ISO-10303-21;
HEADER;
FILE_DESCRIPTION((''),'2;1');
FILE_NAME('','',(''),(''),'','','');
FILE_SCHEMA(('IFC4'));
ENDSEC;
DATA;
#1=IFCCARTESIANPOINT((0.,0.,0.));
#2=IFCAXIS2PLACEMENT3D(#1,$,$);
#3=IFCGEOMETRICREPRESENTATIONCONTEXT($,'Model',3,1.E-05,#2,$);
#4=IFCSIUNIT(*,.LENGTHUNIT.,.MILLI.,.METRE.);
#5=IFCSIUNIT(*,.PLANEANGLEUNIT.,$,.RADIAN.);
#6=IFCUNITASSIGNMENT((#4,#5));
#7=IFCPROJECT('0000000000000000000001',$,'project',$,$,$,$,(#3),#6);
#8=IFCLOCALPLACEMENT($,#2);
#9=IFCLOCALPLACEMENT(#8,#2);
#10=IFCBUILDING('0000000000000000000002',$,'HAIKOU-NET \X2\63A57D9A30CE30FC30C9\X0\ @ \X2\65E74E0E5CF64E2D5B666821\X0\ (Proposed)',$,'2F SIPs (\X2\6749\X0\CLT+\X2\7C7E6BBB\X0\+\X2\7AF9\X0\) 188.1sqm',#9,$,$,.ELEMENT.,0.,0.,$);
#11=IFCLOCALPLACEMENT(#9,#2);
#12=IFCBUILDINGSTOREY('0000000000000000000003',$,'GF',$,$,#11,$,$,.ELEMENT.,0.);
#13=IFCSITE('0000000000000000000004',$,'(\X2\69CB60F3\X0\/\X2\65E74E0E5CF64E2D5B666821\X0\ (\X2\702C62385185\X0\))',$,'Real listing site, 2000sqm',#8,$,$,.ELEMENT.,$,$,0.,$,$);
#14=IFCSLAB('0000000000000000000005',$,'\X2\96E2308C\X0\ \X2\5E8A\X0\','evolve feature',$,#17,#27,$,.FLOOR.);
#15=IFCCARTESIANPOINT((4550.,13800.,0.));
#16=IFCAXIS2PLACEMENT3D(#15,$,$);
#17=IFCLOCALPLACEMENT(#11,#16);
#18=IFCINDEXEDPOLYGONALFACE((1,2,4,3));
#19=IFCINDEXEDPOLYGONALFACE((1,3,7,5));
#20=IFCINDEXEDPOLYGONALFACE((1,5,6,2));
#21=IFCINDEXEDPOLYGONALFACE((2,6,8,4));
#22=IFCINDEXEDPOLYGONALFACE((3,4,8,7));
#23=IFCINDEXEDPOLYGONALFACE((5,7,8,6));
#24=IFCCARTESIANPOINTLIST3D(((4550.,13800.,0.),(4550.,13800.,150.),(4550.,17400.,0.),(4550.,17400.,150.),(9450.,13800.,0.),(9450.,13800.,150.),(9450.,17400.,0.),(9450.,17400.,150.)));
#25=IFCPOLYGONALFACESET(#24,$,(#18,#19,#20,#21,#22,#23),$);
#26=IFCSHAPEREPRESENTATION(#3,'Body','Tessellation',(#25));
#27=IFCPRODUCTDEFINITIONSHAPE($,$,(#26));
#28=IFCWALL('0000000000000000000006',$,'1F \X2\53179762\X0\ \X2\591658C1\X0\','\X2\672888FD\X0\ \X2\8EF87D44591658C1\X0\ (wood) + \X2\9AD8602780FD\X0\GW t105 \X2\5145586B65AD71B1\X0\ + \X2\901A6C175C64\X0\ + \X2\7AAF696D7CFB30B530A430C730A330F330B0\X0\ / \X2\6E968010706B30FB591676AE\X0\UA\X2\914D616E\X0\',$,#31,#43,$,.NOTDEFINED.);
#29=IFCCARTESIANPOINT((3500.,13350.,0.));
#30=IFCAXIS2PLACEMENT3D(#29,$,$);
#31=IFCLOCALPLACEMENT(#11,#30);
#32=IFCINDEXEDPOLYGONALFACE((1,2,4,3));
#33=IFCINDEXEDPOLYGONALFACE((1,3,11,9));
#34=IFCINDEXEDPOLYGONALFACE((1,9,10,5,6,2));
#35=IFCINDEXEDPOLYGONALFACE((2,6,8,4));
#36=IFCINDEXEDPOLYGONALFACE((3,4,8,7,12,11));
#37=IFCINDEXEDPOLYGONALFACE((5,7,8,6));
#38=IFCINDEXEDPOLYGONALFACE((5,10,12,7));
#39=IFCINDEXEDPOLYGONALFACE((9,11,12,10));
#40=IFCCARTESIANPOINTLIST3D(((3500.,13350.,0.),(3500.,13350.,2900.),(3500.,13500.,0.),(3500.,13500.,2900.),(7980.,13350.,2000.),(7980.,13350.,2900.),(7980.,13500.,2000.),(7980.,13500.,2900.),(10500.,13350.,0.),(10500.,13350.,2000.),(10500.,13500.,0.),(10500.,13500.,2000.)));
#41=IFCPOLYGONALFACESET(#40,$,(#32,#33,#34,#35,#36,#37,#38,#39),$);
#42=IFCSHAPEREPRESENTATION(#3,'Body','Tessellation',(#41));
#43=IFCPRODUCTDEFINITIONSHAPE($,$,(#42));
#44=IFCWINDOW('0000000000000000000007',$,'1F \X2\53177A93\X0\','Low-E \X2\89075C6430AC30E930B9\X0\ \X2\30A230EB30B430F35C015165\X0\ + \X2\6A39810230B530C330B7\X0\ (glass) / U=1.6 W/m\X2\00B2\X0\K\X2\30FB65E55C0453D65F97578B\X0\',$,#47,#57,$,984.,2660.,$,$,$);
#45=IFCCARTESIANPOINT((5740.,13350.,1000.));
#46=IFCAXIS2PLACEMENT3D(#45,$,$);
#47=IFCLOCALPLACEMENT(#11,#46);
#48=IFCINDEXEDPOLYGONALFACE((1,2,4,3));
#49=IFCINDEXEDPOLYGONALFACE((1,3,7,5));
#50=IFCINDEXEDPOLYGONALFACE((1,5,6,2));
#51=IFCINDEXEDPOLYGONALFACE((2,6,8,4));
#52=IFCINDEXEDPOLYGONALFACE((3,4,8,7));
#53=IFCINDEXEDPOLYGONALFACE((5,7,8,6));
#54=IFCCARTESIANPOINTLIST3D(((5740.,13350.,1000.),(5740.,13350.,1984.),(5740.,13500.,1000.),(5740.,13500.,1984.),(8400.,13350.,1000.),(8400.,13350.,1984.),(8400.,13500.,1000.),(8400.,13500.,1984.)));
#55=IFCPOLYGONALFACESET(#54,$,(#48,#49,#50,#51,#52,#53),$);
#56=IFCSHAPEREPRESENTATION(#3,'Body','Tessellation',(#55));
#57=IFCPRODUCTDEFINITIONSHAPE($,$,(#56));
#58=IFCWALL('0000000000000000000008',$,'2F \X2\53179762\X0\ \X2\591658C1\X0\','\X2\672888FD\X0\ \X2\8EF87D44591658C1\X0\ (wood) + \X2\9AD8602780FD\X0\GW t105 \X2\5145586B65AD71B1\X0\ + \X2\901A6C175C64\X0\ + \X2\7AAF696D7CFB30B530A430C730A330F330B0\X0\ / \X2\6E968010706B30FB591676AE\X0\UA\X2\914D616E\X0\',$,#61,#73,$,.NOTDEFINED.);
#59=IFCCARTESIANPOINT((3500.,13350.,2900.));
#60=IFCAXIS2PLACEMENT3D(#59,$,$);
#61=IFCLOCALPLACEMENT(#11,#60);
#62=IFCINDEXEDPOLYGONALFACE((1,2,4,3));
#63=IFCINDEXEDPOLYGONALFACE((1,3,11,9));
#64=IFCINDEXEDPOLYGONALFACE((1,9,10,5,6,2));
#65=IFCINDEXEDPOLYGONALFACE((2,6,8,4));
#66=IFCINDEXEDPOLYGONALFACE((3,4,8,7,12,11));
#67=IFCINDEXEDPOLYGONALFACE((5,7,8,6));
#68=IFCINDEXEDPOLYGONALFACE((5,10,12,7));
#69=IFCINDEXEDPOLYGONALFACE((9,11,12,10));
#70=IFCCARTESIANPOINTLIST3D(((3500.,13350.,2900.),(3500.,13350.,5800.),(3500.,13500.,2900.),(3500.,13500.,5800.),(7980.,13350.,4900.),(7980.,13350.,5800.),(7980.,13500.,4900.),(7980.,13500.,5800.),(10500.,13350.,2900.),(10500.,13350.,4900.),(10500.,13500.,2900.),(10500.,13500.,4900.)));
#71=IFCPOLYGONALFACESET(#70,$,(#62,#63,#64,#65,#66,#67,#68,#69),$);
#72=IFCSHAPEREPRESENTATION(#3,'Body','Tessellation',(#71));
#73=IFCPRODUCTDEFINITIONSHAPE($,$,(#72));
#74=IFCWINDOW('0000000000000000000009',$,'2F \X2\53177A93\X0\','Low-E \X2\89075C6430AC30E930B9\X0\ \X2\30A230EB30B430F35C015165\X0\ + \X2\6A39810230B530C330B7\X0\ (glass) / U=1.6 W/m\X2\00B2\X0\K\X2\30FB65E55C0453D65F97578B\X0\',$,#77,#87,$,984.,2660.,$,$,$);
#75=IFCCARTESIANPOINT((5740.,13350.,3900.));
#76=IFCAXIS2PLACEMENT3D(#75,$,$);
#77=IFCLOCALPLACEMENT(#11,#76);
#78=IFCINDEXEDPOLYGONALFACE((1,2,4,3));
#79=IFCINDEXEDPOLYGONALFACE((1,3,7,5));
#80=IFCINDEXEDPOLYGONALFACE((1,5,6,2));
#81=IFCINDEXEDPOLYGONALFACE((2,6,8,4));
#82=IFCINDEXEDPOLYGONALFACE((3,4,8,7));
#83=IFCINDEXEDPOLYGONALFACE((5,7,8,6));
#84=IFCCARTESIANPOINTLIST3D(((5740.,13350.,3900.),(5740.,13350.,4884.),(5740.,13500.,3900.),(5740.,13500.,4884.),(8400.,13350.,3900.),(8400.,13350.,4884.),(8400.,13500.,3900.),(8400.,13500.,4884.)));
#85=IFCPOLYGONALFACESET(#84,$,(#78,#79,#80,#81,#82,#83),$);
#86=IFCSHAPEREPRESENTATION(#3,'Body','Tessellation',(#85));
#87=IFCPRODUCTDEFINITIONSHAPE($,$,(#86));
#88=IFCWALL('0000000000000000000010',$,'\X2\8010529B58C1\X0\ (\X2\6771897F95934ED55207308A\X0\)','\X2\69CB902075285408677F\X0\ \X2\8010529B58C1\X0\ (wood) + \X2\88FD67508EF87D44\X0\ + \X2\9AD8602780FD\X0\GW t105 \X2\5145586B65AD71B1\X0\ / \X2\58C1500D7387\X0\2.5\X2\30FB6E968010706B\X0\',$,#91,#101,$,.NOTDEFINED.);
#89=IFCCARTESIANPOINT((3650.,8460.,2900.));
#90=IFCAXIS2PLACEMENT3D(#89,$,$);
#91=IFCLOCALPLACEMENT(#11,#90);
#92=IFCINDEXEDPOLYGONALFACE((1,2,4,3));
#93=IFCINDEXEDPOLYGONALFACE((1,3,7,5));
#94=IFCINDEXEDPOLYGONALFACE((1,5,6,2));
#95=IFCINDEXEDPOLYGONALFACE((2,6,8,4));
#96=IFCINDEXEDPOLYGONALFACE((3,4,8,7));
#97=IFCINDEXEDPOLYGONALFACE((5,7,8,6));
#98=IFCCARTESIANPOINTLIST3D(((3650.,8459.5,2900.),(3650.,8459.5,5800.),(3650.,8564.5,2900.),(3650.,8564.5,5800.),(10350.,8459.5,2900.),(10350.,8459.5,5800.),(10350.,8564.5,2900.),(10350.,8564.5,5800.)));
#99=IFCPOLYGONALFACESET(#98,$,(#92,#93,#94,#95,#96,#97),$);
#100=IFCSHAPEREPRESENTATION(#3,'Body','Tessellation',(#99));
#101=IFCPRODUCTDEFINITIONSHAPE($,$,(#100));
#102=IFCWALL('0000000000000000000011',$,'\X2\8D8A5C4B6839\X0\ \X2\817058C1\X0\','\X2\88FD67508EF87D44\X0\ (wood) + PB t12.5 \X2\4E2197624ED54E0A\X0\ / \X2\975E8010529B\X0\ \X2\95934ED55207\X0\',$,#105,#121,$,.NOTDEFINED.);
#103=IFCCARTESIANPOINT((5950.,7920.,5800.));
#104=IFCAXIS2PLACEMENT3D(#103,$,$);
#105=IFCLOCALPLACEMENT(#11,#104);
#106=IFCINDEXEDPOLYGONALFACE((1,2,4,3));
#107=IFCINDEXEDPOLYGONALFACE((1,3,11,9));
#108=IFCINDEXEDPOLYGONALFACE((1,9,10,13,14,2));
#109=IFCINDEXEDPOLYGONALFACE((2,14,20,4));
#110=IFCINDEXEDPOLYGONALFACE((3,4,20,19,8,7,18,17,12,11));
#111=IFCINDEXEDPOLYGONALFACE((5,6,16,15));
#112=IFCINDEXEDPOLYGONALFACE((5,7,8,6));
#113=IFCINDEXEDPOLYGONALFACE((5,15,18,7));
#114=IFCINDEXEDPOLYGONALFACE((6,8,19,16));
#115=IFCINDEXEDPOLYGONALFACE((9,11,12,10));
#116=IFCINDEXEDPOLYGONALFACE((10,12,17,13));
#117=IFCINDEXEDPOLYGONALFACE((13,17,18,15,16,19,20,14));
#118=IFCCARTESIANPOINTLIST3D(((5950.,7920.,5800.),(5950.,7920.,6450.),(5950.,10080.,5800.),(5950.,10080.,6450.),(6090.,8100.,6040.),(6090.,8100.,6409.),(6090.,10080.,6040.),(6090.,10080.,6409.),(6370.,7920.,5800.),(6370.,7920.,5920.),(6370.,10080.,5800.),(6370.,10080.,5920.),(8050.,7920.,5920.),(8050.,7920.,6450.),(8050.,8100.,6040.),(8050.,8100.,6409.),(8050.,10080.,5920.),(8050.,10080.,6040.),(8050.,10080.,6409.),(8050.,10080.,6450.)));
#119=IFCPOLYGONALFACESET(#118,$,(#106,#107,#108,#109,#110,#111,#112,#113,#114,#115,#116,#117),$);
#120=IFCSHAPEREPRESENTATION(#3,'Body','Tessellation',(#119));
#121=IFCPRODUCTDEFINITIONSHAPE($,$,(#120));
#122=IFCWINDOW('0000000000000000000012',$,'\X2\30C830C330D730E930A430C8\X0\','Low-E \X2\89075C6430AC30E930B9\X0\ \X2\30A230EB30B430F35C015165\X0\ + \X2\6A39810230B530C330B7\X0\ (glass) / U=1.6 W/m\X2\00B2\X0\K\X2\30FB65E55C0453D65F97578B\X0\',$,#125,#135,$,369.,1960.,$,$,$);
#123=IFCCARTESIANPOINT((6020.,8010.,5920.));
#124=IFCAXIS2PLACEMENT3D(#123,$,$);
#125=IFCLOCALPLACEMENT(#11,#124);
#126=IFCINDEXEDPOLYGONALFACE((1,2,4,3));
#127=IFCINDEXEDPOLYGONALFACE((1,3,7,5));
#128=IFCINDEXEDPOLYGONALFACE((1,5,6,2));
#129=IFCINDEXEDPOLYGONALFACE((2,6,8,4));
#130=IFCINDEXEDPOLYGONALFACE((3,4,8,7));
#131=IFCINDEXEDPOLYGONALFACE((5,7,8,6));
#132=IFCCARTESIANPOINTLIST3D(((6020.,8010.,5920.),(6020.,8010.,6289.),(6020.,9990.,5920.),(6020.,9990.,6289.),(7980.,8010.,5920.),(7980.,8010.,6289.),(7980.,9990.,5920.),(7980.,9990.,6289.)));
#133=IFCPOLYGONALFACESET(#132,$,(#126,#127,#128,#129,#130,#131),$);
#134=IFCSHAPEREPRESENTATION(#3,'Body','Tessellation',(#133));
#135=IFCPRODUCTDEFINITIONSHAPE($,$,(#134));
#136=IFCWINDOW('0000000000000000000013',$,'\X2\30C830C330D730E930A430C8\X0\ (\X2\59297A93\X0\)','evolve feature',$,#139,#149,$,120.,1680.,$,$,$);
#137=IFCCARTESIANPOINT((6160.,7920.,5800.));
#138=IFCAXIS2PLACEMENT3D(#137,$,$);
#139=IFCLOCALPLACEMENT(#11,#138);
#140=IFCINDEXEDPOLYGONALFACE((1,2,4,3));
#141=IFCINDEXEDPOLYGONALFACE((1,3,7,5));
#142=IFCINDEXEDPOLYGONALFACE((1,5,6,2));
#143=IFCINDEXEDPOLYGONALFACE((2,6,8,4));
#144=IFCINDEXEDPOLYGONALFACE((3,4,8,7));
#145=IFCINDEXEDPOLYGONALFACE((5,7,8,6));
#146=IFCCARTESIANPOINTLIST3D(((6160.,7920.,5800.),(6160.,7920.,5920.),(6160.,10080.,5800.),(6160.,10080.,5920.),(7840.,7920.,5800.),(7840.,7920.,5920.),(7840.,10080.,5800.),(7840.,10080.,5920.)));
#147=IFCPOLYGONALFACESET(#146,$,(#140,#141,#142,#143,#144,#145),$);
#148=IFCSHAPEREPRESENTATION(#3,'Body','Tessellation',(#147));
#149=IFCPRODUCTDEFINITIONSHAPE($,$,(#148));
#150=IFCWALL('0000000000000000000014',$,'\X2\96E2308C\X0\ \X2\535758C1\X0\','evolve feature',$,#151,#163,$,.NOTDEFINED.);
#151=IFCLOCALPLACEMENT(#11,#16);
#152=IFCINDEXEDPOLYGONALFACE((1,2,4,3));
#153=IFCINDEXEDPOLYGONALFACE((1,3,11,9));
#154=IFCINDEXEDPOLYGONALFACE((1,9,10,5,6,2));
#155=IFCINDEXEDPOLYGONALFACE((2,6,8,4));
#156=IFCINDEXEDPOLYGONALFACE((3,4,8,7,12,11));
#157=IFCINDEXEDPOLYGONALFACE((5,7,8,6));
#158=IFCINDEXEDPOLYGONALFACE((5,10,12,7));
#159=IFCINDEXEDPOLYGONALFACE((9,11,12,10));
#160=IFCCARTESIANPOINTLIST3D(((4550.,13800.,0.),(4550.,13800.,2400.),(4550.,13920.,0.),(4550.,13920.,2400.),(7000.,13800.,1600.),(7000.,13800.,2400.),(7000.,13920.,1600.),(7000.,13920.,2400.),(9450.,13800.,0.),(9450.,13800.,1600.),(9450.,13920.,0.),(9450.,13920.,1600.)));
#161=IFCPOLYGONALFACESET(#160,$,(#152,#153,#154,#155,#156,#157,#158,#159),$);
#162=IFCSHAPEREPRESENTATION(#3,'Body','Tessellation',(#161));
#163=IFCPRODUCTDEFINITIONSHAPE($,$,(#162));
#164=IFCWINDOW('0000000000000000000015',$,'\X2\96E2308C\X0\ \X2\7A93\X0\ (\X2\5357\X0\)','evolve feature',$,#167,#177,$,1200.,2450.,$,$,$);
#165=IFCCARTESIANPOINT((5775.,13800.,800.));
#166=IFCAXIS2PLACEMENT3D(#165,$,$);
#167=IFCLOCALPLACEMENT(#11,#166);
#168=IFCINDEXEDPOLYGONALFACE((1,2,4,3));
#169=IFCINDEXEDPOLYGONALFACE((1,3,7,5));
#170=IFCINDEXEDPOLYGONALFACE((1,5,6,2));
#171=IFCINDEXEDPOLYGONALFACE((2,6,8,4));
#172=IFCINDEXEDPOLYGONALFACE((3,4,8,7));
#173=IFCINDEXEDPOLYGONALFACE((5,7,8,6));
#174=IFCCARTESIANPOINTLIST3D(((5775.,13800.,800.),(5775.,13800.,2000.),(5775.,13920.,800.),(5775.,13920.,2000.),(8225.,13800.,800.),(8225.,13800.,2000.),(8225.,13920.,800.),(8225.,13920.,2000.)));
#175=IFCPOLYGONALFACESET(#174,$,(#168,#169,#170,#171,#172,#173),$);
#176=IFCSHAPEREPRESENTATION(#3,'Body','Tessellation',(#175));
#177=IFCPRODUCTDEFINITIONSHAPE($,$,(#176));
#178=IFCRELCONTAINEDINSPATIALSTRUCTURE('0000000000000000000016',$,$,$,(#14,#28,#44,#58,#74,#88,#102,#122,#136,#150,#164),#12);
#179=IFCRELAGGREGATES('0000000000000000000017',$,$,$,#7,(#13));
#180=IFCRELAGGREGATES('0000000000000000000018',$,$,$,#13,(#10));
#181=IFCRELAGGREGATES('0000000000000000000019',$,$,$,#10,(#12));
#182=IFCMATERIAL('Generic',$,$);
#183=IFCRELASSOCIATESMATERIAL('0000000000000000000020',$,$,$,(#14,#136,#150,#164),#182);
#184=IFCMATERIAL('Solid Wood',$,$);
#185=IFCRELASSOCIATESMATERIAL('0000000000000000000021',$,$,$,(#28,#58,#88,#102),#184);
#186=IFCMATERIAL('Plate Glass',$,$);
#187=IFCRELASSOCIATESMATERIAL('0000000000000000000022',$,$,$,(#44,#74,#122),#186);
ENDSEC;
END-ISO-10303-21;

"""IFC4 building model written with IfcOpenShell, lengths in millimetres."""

from ifc_helpers import new_model, si_unit, frame, frame_2d, origin, place, context, project, spatial, rectangle, extrude, material, element, fill, save


model = new_model("IFC4")

# Units and contexts
model_context = context("Model", 3, precision=1e-05, world=origin())
ifc_project = project(units=[si_unit("LENGTHUNIT", "METRE", prefix="MILLI"), si_unit("PLANEANGLEUNIT", "RADIAN")], contexts=[model_context])

# Site, building, storey
site_placement = place(None, origin())
site = spatial("IfcSite", under=ifc_project, at=site_placement, Name="(構想/旧与島中学校 (瀬戸内))", ObjectType="Real listing site, 2000sqm", CompositionType="ELEMENT", RefElevation=0.0)
building_placement = place(site_placement, origin())
building = spatial("IfcBuilding", under=site, at=building_placement, Name="HAIKOU-NET 接続ノード @ 旧与島中学校 (Proposed)", ObjectType="2F SIPs (杉CLT+籾殻+竹) 188.1sqm", CompositionType="ELEMENT", ElevationOfRefHeight=0.0, ElevationOfTerrain=0.0)
storey_placement = place(building_placement, origin())
storey = spatial("IfcBuildingStorey", under=building, at=storey_placement, Name="GF", CompositionType="ELEMENT", Elevation=0.0)

# Slab
ifc_material_1 = material(Name="Generic")
slab_placement = place(storey_placement, frame((4550.0, 13800.0, 0.0)))
element("IfcSlab", 1, at=slab_placement, inside=storey, material=ifc_material_1, Name="離れ 床", Description="evolve feature", PredefinedType="FLOOR", context=model_context, shape_type="SweptSolid", body=[
    extrude(rectangle(XDim=4900.0, YDim=3600.0, at=frame_2d((2450.0, 1800.0))), frame((4550.0, 13800.0, 0.0)), (0.0, 0.0, 1.0), 150.0),
])

# Wall, opening, window
ifc_material_2 = material(Name="Solid Wood")
wall_1_placement = place(storey_placement, frame((3500.0, 13350.0, 0.0)))
wall_1 = element("IfcWall", 2, at=wall_1_placement, inside=storey, material=ifc_material_2, Name="1F 北面 外壁", Description="木製 軸組外壁 (wood) + 高性能GW t105 充填断熱 + 通気層 + 窯業系サイディング / 準耐火・外皮UA配慮", PredefinedType="NOTDEFINED", context=model_context, shape_type="SweptSolid", body=[
    extrude(rectangle(XDim=7000.0, YDim=150.0, at=frame_2d((3500.0, 75.0))), frame((3500.0, 13350.0, 0.0)), (0.0, 0.0, 1.0), 2900.0),
])
opening_1_placement = place(storey_placement, frame((5740.0, 13350.0, 1000.0)))
opening_1 = element("IfcOpeningElement", 3, at=opening_1_placement, cuts=wall_1, PredefinedType="NOTDEFINED", context=model_context, shape_type="SweptSolid", body=[
    extrude(rectangle(XDim=2660.0, YDim=150.0, at=frame_2d((1330.0, 75.0))), frame((5740.0, 13350.0, 1000.0)), (0.0, 0.0, 1.0), 984.0),
])
ifc_material_3 = material(Name="Plate Glass")
window_1_placement = place(storey_placement, frame((5740.0, 13350.0, 1000.0)))
window_1 = element("IfcWindow", 4, at=window_1_placement, inside=storey, material=ifc_material_3, Name="1F 北窓", Description="Low-E 複層ガラス アルゴン封入 + 樹脂サッシ (glass) / U=1.6 W/m²K・日射取得型", OverallHeight=984.0, OverallWidth=2660.0, context=model_context, shape_type="SweptSolid", body=[
    extrude(rectangle(XDim=2660.0, YDim=150.0, at=frame_2d((1330.0, 75.0))), frame((5740.0, 13350.0, 1000.0)), (0.0, 0.0, 1.0), 984.0),
])
fill(opening_1, window_1)

# Wall, opening, window
wall_2_placement = place(storey_placement, frame((3500.0, 13350.0, 2900.0)))
wall_2 = element("IfcWall", 5, at=wall_2_placement, inside=storey, material=ifc_material_2, Name="2F 北面 外壁", Description="木製 軸組外壁 (wood) + 高性能GW t105 充填断熱 + 通気層 + 窯業系サイディング / 準耐火・外皮UA配慮", PredefinedType="NOTDEFINED", context=model_context, shape_type="SweptSolid", body=[
    extrude(rectangle(XDim=7000.0, YDim=150.0, at=frame_2d((3500.0, 75.0))), frame((3500.0, 13350.0, 2900.0)), (0.0, 0.0, 1.0), 2900.0),
])
opening_2_placement = place(storey_placement, frame((5740.0, 13350.0, 3900.0)))
opening_2 = element("IfcOpeningElement", 6, at=opening_2_placement, cuts=wall_2, PredefinedType="NOTDEFINED", context=model_context, shape_type="SweptSolid", body=[
    extrude(rectangle(XDim=2660.0, YDim=150.0, at=frame_2d((1330.0, 75.0))), frame((5740.0, 13350.0, 3900.0)), (0.0, 0.0, 1.0), 984.0),
])
window_2_placement = place(storey_placement, frame((5740.0, 13350.0, 3900.0)))
window_2 = element("IfcWindow", 7, at=window_2_placement, inside=storey, material=ifc_material_3, Name="2F 北窓", Description="Low-E 複層ガラス アルゴン封入 + 樹脂サッシ (glass) / U=1.6 W/m²K・日射取得型", OverallHeight=984.0, OverallWidth=2660.0, context=model_context, shape_type="SweptSolid", body=[
    extrude(rectangle(XDim=2660.0, YDim=150.0, at=frame_2d((1330.0, 75.0))), frame((5740.0, 13350.0, 3900.0)), (0.0, 0.0, 1.0), 984.0),
])
fill(opening_2, window_2)

# Wall
wall_3_placement = place(storey_placement, frame((3650.0, 8460.0, 2900.0)))
element("IfcWall", 8, at=wall_3_placement, inside=storey, material=ifc_material_2, Name="耐力壁 (東西間仕切り)", Description="構造用合板 耐力壁 (wood) + 製材軸組 + 高性能GW t105 充填断熱 / 壁倍率2.5・準耐火", PredefinedType="NOTDEFINED", context=model_context, shape_type="SweptSolid", body=[
    extrude(rectangle(XDim=6700.0, YDim=105.0, at=frame_2d((3350.0, 52.0))), frame((3650.0, 8460.0, 2900.0)), (0.0, 0.0, 1.0), 2900.0),
])

# Wall, openings, windows
wall_4_placement = place(storey_placement, frame((5950.0, 7920.0, 5800.0)))
wall_4 = element("IfcWall", 9, at=wall_4_placement, inside=storey, material=ifc_material_2, Name="越屋根 腰壁", Description="製材軸組 (wood) + PB t12.5 両面仕上 / 非耐力 間仕切", PredefinedType="NOTDEFINED", context=model_context, shape_type="SweptSolid", body=[
    extrude(rectangle(XDim=2100.0, YDim=2160.0, at=frame_2d((1050.0, 1080.0))), frame((5950.0, 7920.0, 5800.0)), (0.0, 0.0, 1.0), 650.0),
])
opening_3_placement = place(storey_placement, frame((6020.0, 8010.0, 5920.0)))
opening_3 = element("IfcOpeningElement", 10, at=opening_3_placement, cuts=wall_4, PredefinedType="NOTDEFINED", context=model_context, shape_type="SweptSolid", body=[
    extrude(rectangle(XDim=1960.0, YDim=1980.0, at=frame_2d((980.0, 990.0))), frame((6020.0, 8010.0, 5920.0)), (0.0, 0.0, 1.0), 369.0),
])
opening_4_placement = place(storey_placement, frame((6160.0, 7920.0, 5800.0)))
opening_4 = element("IfcOpeningElement", 11, at=opening_4_placement, cuts=wall_4, PredefinedType="NOTDEFINED", context=model_context, shape_type="SweptSolid", body=[
    extrude(rectangle(XDim=1680.0, YDim=2160.0, at=frame_2d((840.0, 1080.0))), frame((6160.0, 7920.0, 5800.0)), (0.0, 0.0, 1.0), 120.0),
])
window_3_placement = place(storey_placement, frame((6020.0, 8010.0, 5920.0)))
window_3 = element("IfcWindow", 12, at=window_3_placement, inside=storey, material=ifc_material_3, Name="トップライト", Description="Low-E 複層ガラス アルゴン封入 + 樹脂サッシ (glass) / U=1.6 W/m²K・日射取得型", OverallHeight=369.0, OverallWidth=1960.0, context=model_context, shape_type="SweptSolid", body=[
    extrude(rectangle(XDim=1960.0, YDim=1980.0, at=frame_2d((980.0, 990.0))), frame((6020.0, 8010.0, 5920.0)), (0.0, 0.0, 1.0), 369.0),
])
fill(opening_3, window_3)
window_4_placement = place(storey_placement, frame((6160.0, 7920.0, 5800.0)))
window_4 = element("IfcWindow", 13, at=window_4_placement, inside=storey, material=ifc_material_1, Name="トップライト (天窓)", Description="evolve feature", OverallHeight=120.0, OverallWidth=1680.0, context=model_context, shape_type="SweptSolid", body=[
    extrude(rectangle(XDim=1680.0, YDim=2160.0, at=frame_2d((840.0, 1080.0))), frame((6160.0, 7920.0, 5800.0)), (0.0, 0.0, 1.0), 120.0),
])
fill(opening_4, window_4)

# Wall, opening, window
wall_5_placement = place(storey_placement, frame((4550.0, 13800.0, 0.0)))
wall_5 = element("IfcWall", 14, at=wall_5_placement, inside=storey, material=ifc_material_1, Name="離れ 南壁", Description="evolve feature", PredefinedType="NOTDEFINED", context=model_context, shape_type="SweptSolid", body=[
    extrude(rectangle(XDim=4900.0, YDim=120.0, at=frame_2d((2450.0, 60.0))), frame((4550.0, 13800.0, 0.0)), (0.0, 0.0, 1.0), 2400.0),
])
opening_5_placement = place(storey_placement, frame((5775.0, 13800.0, 800.0)))
opening_5 = element("IfcOpeningElement", 15, at=opening_5_placement, cuts=wall_5, PredefinedType="NOTDEFINED", context=model_context, shape_type="SweptSolid", body=[
    extrude(rectangle(XDim=2450.0, YDim=120.0, at=frame_2d((1225.0, 60.0))), frame((5775.0, 13800.0, 800.0)), (0.0, 0.0, 1.0), 1200.0),
])
window_5_placement = place(storey_placement, frame((5775.0, 13800.0, 800.0)))
window_5 = element("IfcWindow", 16, at=window_5_placement, inside=storey, material=ifc_material_1, Name="離れ 窓 (南)", Description="evolve feature", OverallHeight=1200.0, OverallWidth=2450.0, context=model_context, shape_type="SweptSolid", body=[
    extrude(rectangle(XDim=2450.0, YDim=120.0, at=frame_2d((1225.0, 60.0))), frame((5775.0, 13800.0, 800.0)), (0.0, 0.0, 1.0), 1200.0),
])
fill(opening_5, window_5)

save(model, "model.ifc")
